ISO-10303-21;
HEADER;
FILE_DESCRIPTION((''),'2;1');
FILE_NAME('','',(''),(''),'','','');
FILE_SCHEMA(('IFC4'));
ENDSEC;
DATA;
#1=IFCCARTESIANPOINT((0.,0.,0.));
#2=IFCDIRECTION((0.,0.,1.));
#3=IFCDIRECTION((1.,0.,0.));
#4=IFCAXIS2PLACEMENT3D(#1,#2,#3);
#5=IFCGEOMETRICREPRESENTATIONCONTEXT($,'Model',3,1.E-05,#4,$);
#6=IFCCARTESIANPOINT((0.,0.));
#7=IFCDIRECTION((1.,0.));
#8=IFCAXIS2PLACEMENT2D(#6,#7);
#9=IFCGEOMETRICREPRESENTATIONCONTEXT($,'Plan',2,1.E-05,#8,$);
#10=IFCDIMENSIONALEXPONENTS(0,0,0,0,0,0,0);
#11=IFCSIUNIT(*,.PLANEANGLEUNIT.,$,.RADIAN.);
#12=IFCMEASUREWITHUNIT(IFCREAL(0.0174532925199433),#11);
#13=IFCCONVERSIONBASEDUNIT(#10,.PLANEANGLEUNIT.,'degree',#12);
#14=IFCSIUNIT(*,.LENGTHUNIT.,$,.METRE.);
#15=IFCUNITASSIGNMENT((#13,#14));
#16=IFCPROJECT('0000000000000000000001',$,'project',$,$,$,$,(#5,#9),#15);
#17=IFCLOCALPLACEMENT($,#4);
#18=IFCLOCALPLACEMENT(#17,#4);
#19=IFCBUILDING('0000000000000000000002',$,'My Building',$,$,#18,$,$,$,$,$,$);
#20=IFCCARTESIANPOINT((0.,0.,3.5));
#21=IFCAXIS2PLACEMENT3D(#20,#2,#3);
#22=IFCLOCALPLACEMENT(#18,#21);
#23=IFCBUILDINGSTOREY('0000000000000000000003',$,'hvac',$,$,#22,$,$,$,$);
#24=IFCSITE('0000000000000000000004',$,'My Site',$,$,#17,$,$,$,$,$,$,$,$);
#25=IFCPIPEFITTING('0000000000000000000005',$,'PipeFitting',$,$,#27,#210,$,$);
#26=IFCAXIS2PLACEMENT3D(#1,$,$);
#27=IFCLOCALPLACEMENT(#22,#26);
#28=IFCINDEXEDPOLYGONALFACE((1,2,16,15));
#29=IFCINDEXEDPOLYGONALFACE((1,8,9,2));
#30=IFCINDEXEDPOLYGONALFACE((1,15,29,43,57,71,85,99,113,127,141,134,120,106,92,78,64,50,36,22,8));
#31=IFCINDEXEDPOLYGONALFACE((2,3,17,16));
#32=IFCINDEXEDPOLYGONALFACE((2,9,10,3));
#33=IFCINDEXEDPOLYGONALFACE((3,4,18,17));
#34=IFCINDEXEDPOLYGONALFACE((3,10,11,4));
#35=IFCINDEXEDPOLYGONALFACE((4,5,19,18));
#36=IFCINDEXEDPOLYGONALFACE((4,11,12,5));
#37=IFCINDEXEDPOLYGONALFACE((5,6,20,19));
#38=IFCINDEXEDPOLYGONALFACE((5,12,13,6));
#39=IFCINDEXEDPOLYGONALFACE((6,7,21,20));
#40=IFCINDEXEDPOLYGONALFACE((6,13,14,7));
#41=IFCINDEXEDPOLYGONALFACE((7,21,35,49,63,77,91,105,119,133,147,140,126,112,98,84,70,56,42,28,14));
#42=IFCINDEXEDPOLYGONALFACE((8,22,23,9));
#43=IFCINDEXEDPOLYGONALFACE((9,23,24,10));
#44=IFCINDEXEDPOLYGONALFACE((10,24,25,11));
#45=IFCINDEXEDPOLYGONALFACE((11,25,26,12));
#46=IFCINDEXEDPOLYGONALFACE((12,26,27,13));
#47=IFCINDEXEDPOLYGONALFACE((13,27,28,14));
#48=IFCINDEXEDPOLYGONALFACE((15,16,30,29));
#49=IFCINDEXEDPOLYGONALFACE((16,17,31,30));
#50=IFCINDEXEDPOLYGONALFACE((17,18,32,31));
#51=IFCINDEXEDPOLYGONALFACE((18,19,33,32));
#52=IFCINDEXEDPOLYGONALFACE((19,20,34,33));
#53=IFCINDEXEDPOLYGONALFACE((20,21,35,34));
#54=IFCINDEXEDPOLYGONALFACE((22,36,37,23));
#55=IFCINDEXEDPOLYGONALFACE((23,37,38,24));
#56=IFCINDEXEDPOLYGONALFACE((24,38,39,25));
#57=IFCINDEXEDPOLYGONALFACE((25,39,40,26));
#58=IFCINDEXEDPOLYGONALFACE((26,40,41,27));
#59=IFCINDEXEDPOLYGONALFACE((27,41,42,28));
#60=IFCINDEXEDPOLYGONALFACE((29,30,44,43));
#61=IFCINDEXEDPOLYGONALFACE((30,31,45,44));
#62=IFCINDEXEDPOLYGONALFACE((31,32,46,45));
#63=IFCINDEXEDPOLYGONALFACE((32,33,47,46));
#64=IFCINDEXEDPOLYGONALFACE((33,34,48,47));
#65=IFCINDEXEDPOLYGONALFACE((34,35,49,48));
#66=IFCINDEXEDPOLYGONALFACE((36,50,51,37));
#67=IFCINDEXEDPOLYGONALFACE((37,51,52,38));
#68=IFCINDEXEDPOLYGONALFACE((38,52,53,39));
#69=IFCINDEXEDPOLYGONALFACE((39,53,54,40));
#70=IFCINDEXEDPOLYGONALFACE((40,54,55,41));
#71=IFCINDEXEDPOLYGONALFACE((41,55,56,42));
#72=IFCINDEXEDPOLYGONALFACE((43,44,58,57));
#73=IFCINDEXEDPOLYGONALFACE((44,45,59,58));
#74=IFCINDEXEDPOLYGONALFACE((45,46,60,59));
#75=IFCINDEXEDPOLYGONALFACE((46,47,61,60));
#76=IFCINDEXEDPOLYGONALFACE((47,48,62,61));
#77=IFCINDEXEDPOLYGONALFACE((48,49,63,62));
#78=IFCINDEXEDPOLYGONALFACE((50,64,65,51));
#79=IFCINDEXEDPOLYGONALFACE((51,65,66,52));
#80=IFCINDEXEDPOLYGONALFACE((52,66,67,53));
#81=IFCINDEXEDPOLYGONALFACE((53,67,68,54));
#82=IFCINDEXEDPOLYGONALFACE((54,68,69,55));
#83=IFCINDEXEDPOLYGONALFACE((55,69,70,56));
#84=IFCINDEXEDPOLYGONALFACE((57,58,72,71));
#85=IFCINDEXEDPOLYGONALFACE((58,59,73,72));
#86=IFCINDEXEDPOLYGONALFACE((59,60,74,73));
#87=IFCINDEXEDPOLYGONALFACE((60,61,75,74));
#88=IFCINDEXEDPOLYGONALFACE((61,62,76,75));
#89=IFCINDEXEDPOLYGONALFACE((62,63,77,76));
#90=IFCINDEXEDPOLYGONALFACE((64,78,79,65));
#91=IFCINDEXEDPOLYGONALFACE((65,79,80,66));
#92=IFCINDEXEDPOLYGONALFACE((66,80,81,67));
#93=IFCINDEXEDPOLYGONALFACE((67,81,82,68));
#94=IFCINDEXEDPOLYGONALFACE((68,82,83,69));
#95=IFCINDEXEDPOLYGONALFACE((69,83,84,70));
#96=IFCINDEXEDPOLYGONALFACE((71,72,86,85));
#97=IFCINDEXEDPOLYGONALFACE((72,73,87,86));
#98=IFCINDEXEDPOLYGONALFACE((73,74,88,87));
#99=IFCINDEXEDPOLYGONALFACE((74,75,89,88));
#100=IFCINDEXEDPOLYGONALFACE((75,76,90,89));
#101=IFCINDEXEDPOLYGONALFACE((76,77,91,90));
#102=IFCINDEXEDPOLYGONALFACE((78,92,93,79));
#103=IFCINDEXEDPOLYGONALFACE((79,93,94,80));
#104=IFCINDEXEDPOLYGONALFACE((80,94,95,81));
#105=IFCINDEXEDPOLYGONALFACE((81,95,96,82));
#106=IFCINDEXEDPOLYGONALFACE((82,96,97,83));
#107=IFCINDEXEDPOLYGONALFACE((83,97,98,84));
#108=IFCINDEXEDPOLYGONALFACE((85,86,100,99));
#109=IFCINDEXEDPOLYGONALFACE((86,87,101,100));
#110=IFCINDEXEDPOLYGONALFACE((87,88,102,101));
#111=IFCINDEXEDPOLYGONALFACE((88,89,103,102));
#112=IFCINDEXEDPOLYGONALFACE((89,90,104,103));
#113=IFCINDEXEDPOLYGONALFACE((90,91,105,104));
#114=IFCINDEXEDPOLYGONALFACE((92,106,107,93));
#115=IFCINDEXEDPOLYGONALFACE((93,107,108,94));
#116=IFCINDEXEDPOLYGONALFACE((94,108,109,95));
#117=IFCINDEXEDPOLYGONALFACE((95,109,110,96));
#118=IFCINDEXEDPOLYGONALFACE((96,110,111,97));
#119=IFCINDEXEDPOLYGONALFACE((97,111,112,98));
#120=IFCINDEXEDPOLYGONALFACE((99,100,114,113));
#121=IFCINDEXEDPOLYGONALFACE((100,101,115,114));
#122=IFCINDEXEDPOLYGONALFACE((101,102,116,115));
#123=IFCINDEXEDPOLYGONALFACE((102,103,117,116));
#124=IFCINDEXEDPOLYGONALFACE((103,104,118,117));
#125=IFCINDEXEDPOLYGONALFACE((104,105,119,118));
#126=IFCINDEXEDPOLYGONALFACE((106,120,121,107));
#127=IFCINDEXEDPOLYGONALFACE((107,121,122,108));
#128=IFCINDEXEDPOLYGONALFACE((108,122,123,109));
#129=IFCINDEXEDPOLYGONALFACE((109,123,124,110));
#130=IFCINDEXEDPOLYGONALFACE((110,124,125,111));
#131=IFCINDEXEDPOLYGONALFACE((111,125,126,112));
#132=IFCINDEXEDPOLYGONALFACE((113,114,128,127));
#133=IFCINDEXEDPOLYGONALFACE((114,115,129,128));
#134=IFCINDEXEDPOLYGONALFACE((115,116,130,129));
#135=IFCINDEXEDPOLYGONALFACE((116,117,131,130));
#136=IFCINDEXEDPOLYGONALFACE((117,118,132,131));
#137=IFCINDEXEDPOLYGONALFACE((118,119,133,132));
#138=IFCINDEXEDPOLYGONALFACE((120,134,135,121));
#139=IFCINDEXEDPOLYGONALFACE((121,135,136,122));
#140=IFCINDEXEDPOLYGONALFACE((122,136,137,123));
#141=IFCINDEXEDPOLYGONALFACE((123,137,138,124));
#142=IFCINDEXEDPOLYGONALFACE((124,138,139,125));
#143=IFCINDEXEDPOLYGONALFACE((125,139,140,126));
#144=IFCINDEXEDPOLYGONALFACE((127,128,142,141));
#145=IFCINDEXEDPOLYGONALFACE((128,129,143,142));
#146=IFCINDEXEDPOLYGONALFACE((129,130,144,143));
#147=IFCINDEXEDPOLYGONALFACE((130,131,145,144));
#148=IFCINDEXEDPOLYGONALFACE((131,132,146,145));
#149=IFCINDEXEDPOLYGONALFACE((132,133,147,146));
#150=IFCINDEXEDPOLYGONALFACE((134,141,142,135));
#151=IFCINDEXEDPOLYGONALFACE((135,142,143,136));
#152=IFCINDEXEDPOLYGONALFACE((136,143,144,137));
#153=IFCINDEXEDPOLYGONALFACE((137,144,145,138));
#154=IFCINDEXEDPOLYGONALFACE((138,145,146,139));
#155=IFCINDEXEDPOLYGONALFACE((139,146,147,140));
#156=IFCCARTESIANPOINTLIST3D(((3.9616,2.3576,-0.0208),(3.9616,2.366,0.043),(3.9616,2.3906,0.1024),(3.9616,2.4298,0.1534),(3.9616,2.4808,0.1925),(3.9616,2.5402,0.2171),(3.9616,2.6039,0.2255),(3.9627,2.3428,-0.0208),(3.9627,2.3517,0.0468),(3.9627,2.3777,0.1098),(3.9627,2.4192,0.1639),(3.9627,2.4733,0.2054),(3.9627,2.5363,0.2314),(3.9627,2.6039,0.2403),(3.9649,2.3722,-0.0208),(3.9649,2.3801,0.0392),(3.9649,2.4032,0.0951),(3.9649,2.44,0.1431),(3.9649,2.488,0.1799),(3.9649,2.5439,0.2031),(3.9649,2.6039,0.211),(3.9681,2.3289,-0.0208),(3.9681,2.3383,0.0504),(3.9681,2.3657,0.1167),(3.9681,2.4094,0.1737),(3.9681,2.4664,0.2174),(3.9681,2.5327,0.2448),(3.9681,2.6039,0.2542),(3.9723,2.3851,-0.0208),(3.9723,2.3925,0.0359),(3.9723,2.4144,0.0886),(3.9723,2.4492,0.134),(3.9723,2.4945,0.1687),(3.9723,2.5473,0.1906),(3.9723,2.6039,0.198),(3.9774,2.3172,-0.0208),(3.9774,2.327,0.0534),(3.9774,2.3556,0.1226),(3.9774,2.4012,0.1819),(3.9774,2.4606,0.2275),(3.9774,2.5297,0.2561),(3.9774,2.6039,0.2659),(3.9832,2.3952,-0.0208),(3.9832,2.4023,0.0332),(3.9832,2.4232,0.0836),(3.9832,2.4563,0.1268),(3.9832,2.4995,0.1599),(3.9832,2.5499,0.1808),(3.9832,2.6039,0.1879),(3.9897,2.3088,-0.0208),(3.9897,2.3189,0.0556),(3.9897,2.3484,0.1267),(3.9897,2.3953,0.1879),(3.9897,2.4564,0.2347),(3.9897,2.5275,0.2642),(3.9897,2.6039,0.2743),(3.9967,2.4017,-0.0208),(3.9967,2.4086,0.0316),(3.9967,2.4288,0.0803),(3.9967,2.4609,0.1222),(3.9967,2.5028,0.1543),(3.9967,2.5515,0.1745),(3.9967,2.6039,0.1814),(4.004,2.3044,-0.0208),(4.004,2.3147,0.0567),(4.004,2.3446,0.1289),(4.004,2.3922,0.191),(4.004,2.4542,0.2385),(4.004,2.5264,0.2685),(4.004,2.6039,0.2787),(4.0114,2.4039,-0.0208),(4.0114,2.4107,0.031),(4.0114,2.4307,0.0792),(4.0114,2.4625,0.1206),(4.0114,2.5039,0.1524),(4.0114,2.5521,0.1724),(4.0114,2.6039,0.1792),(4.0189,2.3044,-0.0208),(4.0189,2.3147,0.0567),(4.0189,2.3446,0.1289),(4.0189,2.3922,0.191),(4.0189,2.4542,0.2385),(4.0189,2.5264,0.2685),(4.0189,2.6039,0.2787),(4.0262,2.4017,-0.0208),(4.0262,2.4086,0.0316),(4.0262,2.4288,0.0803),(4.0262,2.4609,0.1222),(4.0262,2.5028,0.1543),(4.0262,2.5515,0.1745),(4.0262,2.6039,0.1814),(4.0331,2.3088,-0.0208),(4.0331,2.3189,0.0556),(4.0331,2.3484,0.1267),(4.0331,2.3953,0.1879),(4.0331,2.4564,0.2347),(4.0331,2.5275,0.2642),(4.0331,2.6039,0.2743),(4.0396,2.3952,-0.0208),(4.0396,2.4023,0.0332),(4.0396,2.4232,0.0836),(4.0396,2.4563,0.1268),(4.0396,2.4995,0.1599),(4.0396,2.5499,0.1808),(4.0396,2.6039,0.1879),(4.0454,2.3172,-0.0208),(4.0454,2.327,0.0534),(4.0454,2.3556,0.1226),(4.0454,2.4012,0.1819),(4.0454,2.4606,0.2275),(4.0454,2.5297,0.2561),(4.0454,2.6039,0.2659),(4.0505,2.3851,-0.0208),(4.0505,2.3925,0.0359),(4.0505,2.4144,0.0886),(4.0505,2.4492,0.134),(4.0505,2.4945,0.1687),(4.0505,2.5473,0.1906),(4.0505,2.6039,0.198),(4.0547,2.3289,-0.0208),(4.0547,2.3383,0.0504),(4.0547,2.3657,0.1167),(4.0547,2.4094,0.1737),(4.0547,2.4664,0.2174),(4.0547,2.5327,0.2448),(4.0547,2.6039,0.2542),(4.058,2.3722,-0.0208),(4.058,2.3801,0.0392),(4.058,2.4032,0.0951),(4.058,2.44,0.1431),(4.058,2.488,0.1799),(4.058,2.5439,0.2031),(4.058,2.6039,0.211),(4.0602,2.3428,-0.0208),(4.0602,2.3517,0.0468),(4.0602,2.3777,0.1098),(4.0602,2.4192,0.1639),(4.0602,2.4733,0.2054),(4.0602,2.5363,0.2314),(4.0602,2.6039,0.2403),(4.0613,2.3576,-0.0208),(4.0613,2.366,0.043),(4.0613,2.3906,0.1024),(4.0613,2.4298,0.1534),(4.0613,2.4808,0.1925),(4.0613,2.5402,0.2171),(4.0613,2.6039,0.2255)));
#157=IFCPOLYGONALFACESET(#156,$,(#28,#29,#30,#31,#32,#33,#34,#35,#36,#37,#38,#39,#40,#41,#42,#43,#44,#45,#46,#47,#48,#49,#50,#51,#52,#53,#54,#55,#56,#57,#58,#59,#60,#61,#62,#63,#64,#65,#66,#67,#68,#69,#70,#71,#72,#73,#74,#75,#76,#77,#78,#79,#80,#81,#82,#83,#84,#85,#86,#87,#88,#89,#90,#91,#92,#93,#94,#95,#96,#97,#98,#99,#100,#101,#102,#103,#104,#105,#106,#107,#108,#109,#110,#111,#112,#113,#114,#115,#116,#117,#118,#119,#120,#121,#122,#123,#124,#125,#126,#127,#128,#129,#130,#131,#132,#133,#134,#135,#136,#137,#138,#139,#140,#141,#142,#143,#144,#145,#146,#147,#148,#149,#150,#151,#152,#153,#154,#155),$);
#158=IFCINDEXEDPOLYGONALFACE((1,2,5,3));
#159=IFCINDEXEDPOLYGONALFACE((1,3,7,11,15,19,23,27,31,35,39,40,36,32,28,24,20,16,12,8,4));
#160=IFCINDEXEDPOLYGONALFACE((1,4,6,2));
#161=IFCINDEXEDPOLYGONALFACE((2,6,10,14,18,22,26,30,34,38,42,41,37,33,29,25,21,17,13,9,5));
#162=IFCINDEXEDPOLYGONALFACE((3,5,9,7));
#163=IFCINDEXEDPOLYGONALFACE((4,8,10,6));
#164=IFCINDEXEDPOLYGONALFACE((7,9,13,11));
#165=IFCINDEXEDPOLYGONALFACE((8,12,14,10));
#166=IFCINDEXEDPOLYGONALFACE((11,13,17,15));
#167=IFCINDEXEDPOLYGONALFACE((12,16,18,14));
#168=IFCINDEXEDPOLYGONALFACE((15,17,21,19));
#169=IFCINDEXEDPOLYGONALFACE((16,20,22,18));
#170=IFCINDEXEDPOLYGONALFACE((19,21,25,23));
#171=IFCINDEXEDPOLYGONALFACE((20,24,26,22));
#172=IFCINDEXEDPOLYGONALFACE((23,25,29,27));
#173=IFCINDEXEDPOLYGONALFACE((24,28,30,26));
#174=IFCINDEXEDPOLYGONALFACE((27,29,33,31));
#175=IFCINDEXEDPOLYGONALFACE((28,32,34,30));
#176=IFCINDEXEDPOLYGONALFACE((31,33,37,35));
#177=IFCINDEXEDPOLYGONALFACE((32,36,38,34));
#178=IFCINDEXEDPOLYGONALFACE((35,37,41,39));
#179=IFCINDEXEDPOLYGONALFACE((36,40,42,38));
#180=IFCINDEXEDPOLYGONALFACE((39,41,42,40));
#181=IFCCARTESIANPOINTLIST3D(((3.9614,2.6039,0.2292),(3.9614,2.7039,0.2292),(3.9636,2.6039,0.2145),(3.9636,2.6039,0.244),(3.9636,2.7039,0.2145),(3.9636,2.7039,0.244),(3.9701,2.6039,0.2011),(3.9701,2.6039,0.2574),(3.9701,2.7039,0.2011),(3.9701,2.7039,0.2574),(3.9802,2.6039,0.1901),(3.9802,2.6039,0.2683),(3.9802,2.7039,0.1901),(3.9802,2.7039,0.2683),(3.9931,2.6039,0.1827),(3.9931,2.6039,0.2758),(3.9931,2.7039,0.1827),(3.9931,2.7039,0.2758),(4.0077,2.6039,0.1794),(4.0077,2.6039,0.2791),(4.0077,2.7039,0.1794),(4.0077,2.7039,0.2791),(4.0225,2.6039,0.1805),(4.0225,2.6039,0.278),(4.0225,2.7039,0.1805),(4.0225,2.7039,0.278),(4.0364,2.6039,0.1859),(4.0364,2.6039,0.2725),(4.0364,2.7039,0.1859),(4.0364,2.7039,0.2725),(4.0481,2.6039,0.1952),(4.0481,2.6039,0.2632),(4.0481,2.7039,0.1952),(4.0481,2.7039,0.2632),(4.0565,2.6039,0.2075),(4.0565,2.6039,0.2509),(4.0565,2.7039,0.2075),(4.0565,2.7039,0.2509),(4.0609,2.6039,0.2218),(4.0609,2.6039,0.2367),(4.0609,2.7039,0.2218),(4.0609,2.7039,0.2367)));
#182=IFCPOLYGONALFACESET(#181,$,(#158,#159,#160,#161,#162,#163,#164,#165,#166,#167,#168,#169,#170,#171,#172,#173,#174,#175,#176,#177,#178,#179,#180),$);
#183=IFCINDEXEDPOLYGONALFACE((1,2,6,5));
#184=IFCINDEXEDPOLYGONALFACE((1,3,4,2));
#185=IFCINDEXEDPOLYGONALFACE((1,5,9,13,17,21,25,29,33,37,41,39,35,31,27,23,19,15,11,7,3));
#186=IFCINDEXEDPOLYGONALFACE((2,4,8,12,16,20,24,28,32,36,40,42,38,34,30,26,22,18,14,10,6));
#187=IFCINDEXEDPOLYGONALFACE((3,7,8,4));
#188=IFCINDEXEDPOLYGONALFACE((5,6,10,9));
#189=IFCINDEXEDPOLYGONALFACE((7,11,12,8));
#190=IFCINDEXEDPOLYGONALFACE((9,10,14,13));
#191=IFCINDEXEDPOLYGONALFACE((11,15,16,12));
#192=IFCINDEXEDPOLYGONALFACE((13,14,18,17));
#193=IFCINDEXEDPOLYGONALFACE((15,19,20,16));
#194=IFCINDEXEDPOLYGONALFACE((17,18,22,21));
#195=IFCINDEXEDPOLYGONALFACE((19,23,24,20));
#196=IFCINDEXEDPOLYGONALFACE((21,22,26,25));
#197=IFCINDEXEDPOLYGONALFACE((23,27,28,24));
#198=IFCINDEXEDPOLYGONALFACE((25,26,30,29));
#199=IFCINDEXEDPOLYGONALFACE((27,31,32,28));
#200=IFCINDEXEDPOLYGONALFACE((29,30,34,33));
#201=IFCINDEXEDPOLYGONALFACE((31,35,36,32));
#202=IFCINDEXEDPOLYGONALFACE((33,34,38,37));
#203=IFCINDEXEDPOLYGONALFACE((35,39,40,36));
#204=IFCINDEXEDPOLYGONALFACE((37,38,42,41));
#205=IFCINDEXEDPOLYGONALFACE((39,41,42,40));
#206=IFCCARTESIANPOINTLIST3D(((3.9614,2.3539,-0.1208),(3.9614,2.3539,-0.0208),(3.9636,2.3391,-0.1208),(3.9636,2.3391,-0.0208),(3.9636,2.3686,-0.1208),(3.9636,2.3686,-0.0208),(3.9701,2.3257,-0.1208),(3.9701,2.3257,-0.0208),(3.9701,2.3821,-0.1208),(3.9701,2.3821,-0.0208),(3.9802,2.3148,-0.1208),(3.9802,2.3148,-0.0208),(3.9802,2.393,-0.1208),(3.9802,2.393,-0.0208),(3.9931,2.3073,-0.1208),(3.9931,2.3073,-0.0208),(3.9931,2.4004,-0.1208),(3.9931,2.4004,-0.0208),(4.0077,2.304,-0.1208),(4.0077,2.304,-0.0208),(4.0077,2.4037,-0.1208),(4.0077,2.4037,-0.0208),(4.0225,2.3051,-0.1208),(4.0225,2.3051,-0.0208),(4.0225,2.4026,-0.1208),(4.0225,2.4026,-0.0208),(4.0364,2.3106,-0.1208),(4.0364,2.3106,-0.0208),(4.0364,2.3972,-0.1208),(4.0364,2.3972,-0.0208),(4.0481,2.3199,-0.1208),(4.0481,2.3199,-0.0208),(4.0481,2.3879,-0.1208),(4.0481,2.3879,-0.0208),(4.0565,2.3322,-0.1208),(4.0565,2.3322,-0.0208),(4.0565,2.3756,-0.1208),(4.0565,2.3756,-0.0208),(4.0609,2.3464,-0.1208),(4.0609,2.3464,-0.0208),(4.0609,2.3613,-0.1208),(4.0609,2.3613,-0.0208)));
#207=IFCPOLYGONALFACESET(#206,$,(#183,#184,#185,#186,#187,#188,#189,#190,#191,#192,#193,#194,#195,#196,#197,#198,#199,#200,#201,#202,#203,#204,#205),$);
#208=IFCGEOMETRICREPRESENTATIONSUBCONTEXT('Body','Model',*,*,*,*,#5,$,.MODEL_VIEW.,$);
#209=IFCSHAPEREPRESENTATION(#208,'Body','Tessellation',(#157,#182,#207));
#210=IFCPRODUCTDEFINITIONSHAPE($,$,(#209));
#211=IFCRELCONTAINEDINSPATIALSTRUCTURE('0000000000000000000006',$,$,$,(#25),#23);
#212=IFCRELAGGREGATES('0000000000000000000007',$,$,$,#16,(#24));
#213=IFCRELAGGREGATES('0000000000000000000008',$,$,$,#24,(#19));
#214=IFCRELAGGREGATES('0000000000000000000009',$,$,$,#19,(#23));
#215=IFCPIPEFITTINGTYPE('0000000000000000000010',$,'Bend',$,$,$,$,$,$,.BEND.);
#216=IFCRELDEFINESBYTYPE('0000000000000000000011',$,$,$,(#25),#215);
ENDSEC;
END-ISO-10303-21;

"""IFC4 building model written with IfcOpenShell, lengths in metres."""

from ifc_helpers import new_model, entity, si_unit, converted_unit, frame, origin_with_axes, origin_2d_with_axis, place, context, subcontext, project, spatial, circle, extrude, source, transform, mapped, type_object, type_shapes, element, save


model = new_model("IFC4")

# Units and contexts
model_context = context("Model", 3, precision=1e-05, world=origin_with_axes())
plan_context = context("Plan", 2, precision=1e-05, world=origin_2d_with_axis())
body_context_1 = subcontext(model_context, "Body", "Model", "MODEL_VIEW")
ifc_project = project(units=[converted_unit("PLANEANGLEUNIT", "degree", entity("IfcReal", 0.0174532925199433), si_unit("PLANEANGLEUNIT", "RADIAN"), dimensions=[0, 0, 0, 0, 0, 0, 0]), si_unit("LENGTHUNIT", "METRE")], contexts=[model_context, plan_context])

# Site, building, storey
site_placement = place(None, origin_with_axes())
site = spatial("IfcSite", under=ifc_project, at=site_placement, Name="My Site")
building_placement = place(site_placement, origin_with_axes())
building = spatial("IfcBuilding", under=site, at=building_placement, Name="My Building")
storey_placement = place(building_placement, frame((0.0, 0.0, 3.5), z_axis=(0.0, 0.0, 1.0), x_axis=(1.0, 0.0, 0.0)))
storey = spatial("IfcBuildingStorey", under=building, at=storey_placement, Name="hvac")

# Pipe fitting
pipe_fitting_type = type_object("IfcPipeFittingType", Name="Bend", PredefinedType="BEND")
shared_shape_1 = source(origin_with_axes(), body_context_1, "Body", "SolidModel", [
    entity("IfcSweptDiskSolid", entity("IfcIndexedPolyCurve", entity("IfcCartesianPointList3D", [[0.0, 0.0, -0.1], [0.0, -0.0732, -0.2768], [0.0, -0.25, -0.35]]), [entity("IfcArcIndex", [1, 2, 3])]), 0.05),
    extrude(circle(Radius=0.05), origin_with_axes(), (0.0, 0.0, -1.0), 0.1),
    extrude(circle(Radius=0.05), frame((0.0, -0.25, -0.35), z_axis=(0.0, -1.0, -0.000032), x_axis=(1.0, 0.0, 0.0)), (0.0, 0.0, 1.0), 0.1),
])
type_shapes(pipe_fitting_type, [shared_shape_1])
for number, where, z_axis, x_axis, name in (
    (1, (4.0114, 2.7039, 0.2292), (0.0, 1.0, 0.0), (-1.0, 0.0, 0.0), "PipeFitting"),
):
    element("IfcPipeFitting", number, at=place(storey_placement, frame(where, z_axis=z_axis, x_axis=x_axis)), inside=storey, type_object=pipe_fitting_type, Name=name, context=body_context_1, shape_type="MappedRepresentation", body=[
        mapped(shared_shape_1, transform((0.0, 0.0, 0.0), x_axis=(1.0, 0.0, 0.0), y_axis=(0.0, 1.0, 0.0), z_axis=(0.0, 0.0, 1.0), scale=1.0)),
    ])

save(model, "model.ifc")
